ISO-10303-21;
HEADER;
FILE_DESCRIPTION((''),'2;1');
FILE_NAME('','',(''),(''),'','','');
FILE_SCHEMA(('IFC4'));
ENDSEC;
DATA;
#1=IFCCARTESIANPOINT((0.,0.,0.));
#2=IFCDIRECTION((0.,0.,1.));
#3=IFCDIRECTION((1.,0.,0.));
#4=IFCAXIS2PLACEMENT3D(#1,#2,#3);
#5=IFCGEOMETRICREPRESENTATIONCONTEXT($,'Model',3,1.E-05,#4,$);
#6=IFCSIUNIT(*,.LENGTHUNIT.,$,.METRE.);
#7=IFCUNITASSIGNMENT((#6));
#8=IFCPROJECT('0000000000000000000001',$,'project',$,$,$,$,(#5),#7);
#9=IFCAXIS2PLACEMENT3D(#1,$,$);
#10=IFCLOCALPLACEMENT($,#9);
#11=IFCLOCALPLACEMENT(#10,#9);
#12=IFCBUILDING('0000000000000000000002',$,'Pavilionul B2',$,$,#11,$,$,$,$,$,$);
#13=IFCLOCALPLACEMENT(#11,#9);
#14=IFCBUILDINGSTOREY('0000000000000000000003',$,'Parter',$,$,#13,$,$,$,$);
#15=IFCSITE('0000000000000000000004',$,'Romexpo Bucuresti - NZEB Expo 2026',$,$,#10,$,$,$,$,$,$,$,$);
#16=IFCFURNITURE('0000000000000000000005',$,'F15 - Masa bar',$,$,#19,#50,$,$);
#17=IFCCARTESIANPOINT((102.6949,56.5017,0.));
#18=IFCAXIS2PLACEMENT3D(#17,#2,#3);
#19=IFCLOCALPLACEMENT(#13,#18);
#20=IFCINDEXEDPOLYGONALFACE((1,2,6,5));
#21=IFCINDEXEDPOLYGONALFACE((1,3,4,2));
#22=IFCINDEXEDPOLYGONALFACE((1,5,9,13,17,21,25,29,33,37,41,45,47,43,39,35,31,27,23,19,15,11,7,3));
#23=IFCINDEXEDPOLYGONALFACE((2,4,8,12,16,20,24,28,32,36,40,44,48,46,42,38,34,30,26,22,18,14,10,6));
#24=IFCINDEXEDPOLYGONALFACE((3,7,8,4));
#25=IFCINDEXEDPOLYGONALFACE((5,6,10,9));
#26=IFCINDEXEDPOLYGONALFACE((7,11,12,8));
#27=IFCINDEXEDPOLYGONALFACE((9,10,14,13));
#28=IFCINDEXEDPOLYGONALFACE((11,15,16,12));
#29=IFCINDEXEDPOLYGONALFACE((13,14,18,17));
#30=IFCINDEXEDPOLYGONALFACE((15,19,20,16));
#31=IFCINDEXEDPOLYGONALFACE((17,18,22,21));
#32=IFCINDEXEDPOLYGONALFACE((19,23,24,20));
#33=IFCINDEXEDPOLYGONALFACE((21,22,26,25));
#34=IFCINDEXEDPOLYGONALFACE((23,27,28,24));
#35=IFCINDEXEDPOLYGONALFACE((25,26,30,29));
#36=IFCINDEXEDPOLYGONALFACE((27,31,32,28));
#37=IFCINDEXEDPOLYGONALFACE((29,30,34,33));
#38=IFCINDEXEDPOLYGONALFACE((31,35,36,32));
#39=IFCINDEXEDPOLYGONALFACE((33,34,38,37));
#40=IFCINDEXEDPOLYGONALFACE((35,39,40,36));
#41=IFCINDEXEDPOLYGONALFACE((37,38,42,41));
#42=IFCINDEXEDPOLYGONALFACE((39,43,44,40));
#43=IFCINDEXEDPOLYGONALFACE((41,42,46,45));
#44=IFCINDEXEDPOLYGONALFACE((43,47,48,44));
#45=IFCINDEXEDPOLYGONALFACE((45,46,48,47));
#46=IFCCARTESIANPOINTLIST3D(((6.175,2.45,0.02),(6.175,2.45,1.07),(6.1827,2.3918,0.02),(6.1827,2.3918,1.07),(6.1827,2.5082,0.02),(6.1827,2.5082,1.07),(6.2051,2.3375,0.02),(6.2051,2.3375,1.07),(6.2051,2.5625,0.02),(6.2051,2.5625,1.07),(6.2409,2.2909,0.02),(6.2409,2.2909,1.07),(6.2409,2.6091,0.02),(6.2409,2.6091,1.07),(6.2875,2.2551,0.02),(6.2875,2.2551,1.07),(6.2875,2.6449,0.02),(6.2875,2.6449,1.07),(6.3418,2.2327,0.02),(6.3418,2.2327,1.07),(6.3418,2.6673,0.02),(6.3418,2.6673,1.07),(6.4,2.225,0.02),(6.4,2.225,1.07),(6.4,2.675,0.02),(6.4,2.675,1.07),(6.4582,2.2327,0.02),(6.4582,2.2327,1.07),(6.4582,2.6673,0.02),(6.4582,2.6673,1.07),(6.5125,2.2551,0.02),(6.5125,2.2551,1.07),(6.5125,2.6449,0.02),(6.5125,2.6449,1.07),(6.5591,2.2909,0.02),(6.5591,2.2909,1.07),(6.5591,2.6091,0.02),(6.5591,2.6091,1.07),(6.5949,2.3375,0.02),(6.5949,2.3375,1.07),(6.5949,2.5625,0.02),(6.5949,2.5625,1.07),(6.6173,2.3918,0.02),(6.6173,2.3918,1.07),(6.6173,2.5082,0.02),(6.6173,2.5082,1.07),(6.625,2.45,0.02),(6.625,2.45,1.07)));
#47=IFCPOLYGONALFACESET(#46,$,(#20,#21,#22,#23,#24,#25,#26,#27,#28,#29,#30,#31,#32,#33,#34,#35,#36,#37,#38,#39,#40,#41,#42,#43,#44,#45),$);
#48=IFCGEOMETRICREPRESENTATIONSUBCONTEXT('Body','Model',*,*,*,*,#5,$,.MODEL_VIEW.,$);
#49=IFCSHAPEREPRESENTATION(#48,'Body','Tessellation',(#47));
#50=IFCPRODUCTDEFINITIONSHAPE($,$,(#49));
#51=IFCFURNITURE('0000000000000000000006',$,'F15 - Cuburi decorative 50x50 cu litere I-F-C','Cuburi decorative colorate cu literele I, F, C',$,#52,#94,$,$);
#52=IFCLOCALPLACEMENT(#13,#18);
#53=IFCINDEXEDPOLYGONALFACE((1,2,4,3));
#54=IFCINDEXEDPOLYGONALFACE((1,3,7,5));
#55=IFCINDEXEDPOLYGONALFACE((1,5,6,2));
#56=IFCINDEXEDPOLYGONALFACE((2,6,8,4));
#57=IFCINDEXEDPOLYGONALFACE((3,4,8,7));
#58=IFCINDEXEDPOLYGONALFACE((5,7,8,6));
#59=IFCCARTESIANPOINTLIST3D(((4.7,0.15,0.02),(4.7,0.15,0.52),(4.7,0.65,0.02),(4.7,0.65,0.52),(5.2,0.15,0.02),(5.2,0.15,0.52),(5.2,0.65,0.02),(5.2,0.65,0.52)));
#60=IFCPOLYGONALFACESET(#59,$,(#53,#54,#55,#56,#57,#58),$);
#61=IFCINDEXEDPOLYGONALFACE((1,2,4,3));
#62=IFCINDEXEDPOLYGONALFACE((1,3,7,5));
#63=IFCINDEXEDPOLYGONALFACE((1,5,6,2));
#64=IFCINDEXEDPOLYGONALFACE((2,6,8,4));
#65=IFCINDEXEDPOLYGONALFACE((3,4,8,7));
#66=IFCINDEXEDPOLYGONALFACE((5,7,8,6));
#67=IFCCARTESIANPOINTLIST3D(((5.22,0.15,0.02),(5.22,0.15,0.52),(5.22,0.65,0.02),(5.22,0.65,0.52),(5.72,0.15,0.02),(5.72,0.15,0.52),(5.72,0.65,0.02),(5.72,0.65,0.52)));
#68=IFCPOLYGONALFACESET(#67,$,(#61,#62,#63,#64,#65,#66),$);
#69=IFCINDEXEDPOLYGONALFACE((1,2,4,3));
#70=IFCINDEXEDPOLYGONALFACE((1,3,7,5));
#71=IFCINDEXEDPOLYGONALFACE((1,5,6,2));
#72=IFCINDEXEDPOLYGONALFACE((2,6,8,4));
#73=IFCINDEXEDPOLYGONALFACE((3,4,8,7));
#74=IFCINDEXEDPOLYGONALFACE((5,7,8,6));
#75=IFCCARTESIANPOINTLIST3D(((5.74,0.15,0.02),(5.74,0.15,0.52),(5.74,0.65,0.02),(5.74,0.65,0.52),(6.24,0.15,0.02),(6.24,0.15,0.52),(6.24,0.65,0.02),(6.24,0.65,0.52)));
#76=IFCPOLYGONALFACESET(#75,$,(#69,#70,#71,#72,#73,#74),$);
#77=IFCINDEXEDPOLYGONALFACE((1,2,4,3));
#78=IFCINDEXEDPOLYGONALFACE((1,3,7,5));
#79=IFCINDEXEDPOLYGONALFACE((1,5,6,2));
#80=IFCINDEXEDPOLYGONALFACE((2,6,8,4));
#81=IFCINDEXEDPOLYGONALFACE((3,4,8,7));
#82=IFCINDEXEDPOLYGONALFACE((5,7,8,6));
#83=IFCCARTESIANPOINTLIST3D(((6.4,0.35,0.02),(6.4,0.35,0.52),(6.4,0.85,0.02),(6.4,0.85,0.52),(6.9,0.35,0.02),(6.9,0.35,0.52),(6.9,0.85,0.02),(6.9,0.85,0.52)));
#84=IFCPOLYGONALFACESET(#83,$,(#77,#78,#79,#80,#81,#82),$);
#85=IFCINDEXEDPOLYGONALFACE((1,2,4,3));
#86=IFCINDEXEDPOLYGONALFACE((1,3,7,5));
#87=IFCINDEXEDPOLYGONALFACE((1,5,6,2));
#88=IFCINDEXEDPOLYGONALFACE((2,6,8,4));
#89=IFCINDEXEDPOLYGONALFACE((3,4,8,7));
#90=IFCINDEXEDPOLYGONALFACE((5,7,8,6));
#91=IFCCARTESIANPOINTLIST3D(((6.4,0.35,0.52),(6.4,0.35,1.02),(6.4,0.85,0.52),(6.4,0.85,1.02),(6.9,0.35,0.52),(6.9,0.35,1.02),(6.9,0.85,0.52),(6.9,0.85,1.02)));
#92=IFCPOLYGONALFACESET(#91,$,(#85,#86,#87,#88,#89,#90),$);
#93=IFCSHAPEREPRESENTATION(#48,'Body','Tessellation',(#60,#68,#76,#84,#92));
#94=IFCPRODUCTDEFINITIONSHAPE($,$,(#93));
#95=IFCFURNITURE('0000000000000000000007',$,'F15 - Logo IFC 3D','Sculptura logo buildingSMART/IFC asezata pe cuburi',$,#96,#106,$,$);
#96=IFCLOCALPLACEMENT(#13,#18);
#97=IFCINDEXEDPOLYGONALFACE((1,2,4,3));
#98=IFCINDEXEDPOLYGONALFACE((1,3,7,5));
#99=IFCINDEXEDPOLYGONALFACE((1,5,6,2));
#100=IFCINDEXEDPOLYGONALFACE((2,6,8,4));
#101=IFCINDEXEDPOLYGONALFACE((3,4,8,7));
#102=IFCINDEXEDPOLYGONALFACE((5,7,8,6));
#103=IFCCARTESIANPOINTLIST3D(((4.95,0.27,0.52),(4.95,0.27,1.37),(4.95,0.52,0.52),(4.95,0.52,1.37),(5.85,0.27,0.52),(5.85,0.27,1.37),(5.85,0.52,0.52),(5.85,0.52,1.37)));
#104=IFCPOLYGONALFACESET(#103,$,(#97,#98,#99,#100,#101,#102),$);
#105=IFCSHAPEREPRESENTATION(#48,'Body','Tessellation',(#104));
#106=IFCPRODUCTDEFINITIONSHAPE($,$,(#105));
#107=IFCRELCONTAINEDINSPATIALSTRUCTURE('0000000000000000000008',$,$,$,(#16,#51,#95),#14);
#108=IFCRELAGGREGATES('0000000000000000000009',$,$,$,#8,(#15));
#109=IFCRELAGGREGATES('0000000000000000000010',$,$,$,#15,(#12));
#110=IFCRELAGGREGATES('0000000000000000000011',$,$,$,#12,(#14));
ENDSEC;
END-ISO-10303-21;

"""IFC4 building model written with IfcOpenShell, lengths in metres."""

from ifc_helpers import new_model, si_unit, frame, frame_2d, origin, origin_with_axes, place, context, subcontext, project, spatial, rectangle, circle, extrude, element, save


model = new_model("IFC4")

# Units and contexts
model_context = context("Model", 3, precision=1e-05, world=origin_with_axes())
body_context = subcontext(model_context, "Body", "Model", "MODEL_VIEW")
ifc_project = project(units=[si_unit("LENGTHUNIT", "METRE")], contexts=[model_context])

# Site, building, storey
site_placement = place(None, origin())
site = spatial("IfcSite", under=ifc_project, at=site_placement, Name="Romexpo Bucuresti - NZEB Expo 2026")
building_placement = place(site_placement, origin())
building = spatial("IfcBuilding", under=site, at=building_placement, Name="Pavilionul B2")
storey_placement = place(building_placement, origin())
storey = spatial("IfcBuildingStorey", under=building, at=storey_placement, Name="Parter")

# Furniture
furniture_1_placement = place(storey_placement, frame((102.6949, 56.5017, 0.0), z_axis=(0.0, 0.0, 1.0), x_axis=(1.0, 0.0, 0.0)))
element("IfcFurniture", 1, at=furniture_1_placement, inside=storey, Name="F15 - Masa bar", context=body_context, shape_type="SweptSolid", body=[
    extrude(circle(Radius=0.225, at=frame_2d((6.4, 2.45))), frame((0.0, 0.0, 0.02)), (0.0, 0.0, 1.0), 1.05),
])
furniture_2_placement = place(storey_placement, frame((102.6949, 56.5017, 0.0), z_axis=(0.0, 0.0, 1.0), x_axis=(1.0, 0.0, 0.0)))
element("IfcFurniture", 2, at=furniture_2_placement, inside=storey, Name="F15 - Cuburi decorative 50x50 cu litere I-F-C", Description="Cuburi decorative colorate cu literele I, F, C", context=body_context, shape_type="SweptSolid", body=[
    extrude(rectangle(XDim=0.5, YDim=0.5, at=frame_2d((4.95, 0.4))), frame((0.0, 0.0, 0.02)), (0.0, 0.0, 1.0), 0.5),
    extrude(rectangle(XDim=0.5, YDim=0.5, at=frame_2d((5.47, 0.4))), frame((0.0, 0.0, 0.02)), (0.0, 0.0, 1.0), 0.5),
    extrude(rectangle(XDim=0.5, YDim=0.5, at=frame_2d((5.99, 0.4))), frame((0.0, 0.0, 0.02)), (0.0, 0.0, 1.0), 0.5),
    extrude(rectangle(XDim=0.5, YDim=0.5, at=frame_2d((6.65, 0.6))), frame((0.0, 0.0, 0.02)), (0.0, 0.0, 1.0), 0.5),
    extrude(rectangle(XDim=0.5, YDim=0.5, at=frame_2d((6.65, 0.6))), frame((0.0, 0.0, 0.52)), (0.0, 0.0, 1.0), 0.5),
])
furniture_3_placement = place(storey_placement, frame((102.6949, 56.5017, 0.0), z_axis=(0.0, 0.0, 1.0), x_axis=(1.0, 0.0, 0.0)))
element("IfcFurniture", 3, at=furniture_3_placement, inside=storey, Name="F15 - Logo IFC 3D", Description="Sculptura logo buildingSMART/IFC asezata pe cuburi", context=body_context, shape_type="SweptSolid", body=[
    extrude(rectangle(XDim=0.9, YDim=0.25, at=frame_2d((5.4, 0.395))), frame((0.0, 0.0, 0.52)), (0.0, 0.0, 1.0), 0.85),
])

save(model, "model.ifc")
